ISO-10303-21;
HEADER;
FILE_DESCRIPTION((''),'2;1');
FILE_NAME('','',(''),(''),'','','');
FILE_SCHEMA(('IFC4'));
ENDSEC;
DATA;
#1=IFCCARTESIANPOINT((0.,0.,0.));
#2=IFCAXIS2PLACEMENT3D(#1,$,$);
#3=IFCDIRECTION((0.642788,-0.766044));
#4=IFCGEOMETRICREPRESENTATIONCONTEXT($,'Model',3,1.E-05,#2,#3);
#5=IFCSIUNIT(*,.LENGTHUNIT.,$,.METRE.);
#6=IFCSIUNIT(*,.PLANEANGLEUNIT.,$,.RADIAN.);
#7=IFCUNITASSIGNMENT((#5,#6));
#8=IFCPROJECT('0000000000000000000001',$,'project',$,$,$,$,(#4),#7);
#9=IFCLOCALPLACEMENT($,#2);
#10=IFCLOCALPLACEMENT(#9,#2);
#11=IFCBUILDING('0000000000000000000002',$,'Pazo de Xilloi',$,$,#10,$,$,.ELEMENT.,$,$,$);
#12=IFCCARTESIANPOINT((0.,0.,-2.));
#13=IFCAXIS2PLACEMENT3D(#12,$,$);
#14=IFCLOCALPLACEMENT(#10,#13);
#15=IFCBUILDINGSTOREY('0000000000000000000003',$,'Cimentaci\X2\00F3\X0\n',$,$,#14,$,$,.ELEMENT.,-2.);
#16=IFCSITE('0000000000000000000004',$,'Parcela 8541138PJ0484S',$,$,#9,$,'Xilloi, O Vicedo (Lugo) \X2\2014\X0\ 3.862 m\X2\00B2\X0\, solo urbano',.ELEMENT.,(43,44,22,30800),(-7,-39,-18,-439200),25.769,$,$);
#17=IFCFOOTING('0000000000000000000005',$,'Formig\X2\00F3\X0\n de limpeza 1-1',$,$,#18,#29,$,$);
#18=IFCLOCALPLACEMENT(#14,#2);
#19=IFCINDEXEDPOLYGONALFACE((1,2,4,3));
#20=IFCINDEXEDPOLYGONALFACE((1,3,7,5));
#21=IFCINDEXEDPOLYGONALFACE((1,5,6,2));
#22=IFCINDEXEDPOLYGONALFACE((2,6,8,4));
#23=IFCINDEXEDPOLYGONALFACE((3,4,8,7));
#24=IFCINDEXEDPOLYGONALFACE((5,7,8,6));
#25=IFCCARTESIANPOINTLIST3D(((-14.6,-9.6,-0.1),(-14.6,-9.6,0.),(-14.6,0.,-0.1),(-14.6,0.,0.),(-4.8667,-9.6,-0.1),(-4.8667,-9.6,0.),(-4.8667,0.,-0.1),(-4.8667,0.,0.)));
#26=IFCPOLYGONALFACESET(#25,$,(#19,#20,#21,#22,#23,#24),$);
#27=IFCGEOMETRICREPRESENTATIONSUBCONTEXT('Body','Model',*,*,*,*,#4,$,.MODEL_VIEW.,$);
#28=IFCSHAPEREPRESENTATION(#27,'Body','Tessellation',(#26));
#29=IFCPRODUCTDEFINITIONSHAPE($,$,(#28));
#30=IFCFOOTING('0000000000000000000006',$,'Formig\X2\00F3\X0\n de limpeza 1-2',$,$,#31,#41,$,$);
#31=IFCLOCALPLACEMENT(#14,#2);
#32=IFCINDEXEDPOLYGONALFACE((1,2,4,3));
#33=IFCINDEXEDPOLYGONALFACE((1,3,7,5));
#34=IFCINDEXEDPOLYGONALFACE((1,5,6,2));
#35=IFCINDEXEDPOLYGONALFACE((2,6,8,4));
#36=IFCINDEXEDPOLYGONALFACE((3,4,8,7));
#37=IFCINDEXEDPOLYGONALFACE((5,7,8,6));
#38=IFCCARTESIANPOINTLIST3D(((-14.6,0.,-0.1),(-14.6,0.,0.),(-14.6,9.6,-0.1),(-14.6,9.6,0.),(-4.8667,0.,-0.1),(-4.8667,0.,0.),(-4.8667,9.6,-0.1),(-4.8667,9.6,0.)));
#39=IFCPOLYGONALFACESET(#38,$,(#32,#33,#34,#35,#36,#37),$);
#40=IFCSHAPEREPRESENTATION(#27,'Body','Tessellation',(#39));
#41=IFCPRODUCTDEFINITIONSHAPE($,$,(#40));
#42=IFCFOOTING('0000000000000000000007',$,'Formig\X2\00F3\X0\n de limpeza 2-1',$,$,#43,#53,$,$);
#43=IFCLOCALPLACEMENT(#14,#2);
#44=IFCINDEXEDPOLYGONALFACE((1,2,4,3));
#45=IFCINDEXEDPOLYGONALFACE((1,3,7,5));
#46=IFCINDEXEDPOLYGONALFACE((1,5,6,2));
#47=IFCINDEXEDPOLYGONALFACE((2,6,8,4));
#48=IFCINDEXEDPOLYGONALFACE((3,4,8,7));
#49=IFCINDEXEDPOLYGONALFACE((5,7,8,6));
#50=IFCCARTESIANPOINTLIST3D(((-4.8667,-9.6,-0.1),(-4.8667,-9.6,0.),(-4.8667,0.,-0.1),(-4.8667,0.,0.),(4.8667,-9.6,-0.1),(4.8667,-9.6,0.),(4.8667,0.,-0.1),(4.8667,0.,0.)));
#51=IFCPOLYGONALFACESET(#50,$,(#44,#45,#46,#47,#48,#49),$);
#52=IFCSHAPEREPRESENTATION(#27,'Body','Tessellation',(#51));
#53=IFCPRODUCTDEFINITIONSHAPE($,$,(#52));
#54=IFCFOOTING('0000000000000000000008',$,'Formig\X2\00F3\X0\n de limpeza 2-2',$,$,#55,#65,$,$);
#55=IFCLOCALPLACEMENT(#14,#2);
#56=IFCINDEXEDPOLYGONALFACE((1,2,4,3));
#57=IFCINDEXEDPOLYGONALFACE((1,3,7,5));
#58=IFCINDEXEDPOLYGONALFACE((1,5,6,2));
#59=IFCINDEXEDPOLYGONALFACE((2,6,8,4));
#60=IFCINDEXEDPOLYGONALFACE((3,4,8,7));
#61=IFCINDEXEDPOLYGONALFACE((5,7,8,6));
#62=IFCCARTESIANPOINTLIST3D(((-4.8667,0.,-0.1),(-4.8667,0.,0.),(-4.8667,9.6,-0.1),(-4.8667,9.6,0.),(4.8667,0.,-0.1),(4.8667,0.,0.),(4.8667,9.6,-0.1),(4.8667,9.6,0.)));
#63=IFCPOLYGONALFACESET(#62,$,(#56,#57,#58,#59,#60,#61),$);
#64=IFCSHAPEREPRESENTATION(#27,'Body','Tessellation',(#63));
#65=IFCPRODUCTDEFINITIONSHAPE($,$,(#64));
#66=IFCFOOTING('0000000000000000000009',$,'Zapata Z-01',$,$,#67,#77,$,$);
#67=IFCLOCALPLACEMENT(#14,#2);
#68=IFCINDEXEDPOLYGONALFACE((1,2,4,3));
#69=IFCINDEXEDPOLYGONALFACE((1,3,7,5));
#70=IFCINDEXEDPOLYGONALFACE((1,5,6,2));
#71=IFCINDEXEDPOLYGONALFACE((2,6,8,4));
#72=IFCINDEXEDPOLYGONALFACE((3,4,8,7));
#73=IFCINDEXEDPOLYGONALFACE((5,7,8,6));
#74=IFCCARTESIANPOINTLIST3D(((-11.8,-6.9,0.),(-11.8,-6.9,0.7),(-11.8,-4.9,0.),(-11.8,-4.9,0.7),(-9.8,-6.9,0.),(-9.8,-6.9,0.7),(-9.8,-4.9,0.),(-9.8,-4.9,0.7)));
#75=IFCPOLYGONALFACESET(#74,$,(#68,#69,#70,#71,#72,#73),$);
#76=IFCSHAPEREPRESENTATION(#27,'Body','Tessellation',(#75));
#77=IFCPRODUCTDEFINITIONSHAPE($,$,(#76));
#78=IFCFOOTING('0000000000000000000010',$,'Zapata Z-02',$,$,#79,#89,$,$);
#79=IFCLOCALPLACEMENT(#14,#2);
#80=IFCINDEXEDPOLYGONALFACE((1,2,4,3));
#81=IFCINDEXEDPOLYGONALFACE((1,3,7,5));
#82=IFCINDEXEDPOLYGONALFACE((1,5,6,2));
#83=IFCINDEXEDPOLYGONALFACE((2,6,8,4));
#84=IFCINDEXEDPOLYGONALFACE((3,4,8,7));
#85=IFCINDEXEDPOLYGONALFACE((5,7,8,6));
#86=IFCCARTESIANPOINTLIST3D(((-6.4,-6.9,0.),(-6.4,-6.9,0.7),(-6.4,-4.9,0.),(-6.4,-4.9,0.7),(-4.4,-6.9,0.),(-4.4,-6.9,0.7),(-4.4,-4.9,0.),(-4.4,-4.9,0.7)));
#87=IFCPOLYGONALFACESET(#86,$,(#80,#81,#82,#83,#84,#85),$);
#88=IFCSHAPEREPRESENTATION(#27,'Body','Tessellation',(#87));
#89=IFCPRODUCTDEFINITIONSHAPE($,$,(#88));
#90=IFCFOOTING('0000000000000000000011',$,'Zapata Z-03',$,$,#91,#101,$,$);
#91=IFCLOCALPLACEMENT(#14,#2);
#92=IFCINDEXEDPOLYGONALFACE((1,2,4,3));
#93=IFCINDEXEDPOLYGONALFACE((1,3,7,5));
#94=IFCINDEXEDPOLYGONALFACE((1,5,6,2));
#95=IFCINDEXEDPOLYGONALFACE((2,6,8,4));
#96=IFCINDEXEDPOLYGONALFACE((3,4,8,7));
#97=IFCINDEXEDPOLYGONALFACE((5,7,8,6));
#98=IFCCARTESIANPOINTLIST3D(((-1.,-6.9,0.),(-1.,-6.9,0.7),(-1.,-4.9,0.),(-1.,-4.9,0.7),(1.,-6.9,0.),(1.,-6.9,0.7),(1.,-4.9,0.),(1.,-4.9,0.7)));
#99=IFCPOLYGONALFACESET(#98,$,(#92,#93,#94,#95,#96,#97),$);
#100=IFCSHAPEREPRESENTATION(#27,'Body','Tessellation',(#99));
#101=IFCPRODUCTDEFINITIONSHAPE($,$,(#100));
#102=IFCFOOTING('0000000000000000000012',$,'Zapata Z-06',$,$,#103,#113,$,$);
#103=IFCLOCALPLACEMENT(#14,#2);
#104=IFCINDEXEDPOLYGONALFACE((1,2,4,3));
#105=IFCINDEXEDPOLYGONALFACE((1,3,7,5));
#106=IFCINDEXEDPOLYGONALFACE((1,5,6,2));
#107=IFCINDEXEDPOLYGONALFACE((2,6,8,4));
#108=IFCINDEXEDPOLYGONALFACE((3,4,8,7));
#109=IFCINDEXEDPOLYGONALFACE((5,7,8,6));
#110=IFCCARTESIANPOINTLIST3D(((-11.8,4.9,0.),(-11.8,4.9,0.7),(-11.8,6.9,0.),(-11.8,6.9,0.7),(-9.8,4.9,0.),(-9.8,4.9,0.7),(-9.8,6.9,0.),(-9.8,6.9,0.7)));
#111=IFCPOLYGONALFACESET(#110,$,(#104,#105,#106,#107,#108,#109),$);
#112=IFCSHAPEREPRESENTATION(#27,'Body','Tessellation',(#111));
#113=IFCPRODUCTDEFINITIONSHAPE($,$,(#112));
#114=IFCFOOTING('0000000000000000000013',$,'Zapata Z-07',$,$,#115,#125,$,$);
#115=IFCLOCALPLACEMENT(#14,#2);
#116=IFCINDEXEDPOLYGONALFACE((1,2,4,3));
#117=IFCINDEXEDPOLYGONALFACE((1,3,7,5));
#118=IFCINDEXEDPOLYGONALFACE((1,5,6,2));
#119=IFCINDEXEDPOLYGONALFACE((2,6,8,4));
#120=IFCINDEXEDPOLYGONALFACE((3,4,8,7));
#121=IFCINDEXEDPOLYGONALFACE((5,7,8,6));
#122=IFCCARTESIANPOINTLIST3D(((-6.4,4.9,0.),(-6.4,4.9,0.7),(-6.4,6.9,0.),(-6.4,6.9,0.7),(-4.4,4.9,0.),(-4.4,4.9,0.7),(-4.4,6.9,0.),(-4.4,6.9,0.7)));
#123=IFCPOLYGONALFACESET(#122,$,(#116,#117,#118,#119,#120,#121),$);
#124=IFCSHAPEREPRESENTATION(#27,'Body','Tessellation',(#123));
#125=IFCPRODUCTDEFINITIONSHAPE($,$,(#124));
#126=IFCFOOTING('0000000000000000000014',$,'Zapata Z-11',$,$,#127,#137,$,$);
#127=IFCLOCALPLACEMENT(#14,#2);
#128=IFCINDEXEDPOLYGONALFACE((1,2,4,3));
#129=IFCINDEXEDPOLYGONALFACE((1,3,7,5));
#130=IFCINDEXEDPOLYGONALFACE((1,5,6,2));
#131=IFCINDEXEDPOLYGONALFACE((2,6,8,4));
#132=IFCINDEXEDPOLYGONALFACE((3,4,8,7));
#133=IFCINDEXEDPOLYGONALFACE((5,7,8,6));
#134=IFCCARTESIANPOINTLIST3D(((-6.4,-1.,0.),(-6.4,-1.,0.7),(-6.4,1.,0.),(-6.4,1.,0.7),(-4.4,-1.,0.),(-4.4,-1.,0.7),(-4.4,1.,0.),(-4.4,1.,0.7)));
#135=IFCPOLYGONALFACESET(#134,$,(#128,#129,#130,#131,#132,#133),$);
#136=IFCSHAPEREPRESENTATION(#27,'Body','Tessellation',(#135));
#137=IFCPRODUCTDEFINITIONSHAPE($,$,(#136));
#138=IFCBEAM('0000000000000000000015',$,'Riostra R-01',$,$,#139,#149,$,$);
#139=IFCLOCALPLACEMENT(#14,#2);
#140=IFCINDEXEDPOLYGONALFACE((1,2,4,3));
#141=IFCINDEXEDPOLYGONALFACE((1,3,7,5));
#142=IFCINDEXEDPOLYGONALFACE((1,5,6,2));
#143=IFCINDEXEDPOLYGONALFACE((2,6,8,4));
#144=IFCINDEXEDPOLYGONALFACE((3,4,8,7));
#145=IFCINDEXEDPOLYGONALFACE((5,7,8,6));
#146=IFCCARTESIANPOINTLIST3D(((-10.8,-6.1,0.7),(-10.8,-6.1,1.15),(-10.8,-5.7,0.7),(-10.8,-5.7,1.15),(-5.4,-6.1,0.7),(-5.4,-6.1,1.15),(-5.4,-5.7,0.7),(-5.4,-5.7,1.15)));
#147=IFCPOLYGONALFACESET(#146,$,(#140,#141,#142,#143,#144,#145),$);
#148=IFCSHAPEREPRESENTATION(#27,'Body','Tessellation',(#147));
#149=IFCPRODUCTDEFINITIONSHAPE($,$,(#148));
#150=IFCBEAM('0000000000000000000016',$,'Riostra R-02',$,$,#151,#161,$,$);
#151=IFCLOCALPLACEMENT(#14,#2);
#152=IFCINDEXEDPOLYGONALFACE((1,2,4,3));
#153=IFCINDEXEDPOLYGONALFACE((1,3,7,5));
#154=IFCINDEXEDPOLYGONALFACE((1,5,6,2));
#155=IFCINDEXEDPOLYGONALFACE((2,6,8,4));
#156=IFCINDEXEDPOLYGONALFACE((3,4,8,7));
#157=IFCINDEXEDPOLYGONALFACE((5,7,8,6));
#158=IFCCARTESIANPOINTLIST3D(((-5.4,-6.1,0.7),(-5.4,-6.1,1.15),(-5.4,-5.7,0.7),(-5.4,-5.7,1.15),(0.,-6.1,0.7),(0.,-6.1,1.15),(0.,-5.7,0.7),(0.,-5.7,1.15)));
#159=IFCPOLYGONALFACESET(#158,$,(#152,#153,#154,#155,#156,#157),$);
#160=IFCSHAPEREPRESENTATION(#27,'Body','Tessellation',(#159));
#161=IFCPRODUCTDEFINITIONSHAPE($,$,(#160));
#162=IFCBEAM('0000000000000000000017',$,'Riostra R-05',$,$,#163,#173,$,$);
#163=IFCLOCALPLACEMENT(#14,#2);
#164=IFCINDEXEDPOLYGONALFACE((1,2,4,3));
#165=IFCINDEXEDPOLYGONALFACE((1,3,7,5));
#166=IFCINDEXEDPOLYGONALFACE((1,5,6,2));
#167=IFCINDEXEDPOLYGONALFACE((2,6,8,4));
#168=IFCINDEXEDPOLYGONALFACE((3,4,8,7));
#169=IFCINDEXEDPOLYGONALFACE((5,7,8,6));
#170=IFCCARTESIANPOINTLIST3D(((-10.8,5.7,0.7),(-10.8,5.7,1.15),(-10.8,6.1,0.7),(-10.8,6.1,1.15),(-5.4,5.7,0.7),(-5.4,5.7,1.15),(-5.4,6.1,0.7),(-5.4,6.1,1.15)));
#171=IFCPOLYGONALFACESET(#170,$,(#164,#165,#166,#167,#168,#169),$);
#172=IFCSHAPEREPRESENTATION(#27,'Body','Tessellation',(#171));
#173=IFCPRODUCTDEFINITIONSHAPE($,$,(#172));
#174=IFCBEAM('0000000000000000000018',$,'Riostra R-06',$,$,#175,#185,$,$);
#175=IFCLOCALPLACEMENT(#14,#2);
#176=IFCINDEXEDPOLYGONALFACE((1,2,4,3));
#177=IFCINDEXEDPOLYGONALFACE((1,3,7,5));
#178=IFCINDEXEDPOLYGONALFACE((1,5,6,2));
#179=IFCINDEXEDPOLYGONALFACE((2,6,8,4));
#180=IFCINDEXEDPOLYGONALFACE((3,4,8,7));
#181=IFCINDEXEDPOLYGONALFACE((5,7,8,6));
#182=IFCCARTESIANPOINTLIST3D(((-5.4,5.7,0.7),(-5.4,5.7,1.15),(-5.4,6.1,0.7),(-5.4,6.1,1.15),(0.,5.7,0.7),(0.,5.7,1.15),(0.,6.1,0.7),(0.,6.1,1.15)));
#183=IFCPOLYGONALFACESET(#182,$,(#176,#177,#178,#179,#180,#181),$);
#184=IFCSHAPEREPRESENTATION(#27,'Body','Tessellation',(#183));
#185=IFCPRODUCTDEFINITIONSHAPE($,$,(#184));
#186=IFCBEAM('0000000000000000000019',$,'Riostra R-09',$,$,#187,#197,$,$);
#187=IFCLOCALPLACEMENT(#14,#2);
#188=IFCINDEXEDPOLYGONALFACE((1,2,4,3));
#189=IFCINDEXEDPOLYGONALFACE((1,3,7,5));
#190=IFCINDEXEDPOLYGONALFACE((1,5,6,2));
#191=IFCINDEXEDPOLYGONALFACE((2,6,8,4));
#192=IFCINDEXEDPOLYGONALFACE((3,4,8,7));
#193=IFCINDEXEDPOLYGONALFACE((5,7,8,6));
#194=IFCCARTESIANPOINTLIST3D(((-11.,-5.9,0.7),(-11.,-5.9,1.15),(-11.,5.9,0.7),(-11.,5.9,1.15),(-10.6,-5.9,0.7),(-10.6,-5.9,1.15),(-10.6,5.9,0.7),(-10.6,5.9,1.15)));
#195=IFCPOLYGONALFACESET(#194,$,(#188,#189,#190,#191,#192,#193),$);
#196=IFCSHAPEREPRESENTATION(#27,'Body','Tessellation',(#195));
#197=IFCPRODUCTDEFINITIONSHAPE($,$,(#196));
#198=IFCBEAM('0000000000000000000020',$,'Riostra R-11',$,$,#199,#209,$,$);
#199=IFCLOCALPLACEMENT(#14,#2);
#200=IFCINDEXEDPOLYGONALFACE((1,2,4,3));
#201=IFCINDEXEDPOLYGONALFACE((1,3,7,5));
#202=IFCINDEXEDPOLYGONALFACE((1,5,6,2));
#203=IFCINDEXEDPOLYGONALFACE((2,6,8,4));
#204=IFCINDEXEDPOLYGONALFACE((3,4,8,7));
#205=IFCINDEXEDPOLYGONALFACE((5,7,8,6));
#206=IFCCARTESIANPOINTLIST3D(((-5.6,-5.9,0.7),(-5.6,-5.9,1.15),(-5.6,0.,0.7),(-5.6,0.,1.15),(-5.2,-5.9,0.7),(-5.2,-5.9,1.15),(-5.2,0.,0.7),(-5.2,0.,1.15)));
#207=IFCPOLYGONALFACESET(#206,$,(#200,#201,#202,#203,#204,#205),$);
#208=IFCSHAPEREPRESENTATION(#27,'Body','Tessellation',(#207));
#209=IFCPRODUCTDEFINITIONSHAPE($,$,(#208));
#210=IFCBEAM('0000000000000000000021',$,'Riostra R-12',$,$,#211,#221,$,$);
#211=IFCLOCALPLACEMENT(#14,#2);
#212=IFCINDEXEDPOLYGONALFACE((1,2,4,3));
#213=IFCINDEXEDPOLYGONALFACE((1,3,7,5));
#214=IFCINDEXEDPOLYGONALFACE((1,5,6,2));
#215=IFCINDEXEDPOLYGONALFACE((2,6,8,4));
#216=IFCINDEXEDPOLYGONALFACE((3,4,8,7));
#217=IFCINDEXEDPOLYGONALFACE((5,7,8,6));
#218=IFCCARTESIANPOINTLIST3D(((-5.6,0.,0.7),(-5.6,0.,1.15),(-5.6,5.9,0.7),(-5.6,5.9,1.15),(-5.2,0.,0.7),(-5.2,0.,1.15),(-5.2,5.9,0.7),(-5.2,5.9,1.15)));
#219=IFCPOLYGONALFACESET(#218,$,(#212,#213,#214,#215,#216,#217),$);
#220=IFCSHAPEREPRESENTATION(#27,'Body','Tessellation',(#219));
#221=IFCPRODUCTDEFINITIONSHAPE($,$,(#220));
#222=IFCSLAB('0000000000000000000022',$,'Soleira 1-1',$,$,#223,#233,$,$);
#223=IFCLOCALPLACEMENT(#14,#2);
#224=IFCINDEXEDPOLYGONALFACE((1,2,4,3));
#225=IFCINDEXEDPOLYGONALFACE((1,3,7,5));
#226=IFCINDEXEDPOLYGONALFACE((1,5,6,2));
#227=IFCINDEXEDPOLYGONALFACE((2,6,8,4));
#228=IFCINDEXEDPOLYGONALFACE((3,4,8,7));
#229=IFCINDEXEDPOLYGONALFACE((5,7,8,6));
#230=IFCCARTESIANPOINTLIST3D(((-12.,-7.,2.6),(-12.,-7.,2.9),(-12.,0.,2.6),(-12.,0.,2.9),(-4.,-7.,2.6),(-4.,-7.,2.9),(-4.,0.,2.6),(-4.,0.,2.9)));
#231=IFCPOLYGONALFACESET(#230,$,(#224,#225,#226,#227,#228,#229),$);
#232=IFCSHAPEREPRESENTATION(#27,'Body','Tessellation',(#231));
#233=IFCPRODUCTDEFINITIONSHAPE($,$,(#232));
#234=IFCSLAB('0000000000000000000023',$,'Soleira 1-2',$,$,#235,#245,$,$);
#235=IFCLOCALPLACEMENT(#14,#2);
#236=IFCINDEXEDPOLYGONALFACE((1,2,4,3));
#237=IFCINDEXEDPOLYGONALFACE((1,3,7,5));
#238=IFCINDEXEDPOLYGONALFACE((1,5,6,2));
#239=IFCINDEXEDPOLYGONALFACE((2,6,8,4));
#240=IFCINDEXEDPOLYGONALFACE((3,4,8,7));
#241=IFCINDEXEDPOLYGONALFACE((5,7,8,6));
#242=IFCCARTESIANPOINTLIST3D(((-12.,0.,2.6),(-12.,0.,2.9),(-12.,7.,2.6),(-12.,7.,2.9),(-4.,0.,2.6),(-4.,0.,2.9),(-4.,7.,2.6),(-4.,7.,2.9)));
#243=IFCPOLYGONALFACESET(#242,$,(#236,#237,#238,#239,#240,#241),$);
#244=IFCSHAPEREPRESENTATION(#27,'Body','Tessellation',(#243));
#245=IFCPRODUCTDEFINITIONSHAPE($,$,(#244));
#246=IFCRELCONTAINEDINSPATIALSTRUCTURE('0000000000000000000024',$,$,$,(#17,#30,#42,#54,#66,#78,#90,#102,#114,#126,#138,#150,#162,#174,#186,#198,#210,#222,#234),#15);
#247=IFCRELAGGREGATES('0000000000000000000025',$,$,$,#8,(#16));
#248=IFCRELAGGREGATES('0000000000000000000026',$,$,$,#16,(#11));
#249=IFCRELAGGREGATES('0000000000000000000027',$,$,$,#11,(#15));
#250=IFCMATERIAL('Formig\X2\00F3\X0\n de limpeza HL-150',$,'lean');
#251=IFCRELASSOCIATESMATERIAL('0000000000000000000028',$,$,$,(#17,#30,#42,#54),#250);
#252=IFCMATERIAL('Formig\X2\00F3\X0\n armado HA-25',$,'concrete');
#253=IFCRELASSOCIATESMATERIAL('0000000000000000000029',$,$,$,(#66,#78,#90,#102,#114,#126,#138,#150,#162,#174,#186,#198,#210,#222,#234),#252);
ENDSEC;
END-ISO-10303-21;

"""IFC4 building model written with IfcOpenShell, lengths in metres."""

from ifc_helpers import new_model, si_unit, direction, frame, origin, origin_2d, place, context, subcontext, project, spatial, rectangle, extrude, material, element, save


model = new_model("IFC4")

# Units and contexts
model_context = context("Model", 3, precision=1e-05, world=origin(), true_north=direction((0.642788, -0.766044)))
body_context = subcontext(model_context, "Body", "Model", "MODEL_VIEW")
ifc_project = project(units=[si_unit("LENGTHUNIT", "METRE"), si_unit("PLANEANGLEUNIT", "RADIAN")], contexts=[model_context])

# Site, building, storey
site_placement = place(None, origin())
site = spatial("IfcSite", under=ifc_project, at=site_placement, Name="Parcela 8541138PJ0484S", LongName="Xilloi, O Vicedo (Lugo) — 3.862 m², solo urbano", CompositionType="ELEMENT", RefLatitude=(43, 44, 22, 30800), RefLongitude=(-7, -39, -18, -439200), RefElevation=25.769)
building_placement = place(site_placement, origin())
building = spatial("IfcBuilding", under=site, at=building_placement, Name="Pazo de Xilloi", CompositionType="ELEMENT")
storey_placement = place(building_placement, frame((0.0, 0.0, -2.0)))
storey = spatial("IfcBuildingStorey", under=building, at=storey_placement, Name="Cimentación", CompositionType="ELEMENT", Elevation=-2.0)

# Footings
ifc_material_1 = material(Name="Formigón de limpeza HL-150", Category="lean")
for number, where, name in (
    (1, (-9.7333, -4.8, -0.05), "Formigón de limpeza 1-1"),
    (2, (-9.7333, 4.8, -0.05), "Formigón de limpeza 1-2"),
    (3, (0.0, -4.8, -0.05), "Formigón de limpeza 2-1"),
    (4, (0.0, 4.8, -0.05), "Formigón de limpeza 2-2"),
):
    element("IfcFooting", number, at=place(storey_placement, frame(where)), inside=storey, material=ifc_material_1, Name=name, context=body_context, shape_type="SweptSolid", body=[
        extrude(rectangle(XDim=9.7333, YDim=9.6, at=origin_2d()), frame((0.0, 0.0, -0.05)), (0.0, 0.0, 1.0), 0.1),
    ])
ifc_material_2 = material(Name="Formigón armado HA-25", Category="concrete")
for number, where, name in (
    (5, (-10.8, -5.9, 0.35), "Zapata Z-01"),
    (6, (-5.4, -5.9, 0.35), "Zapata Z-02"),
    (7, (0.0, -5.9, 0.35), "Zapata Z-03"),
    (8, (-10.8, 5.9, 0.35), "Zapata Z-06"),
    (9, (-5.4, 5.9, 0.35), "Zapata Z-07"),
    (10, (-5.4, 0.0, 0.35), "Zapata Z-11"),
):
    element("IfcFooting", number, at=place(storey_placement, frame(where)), inside=storey, material=ifc_material_2, Name=name, context=body_context, shape_type="SweptSolid", body=[
        extrude(rectangle(XDim=2.0, YDim=2.0, at=origin_2d()), frame((0.0, 0.0, -0.35)), (0.0, 0.0, 1.0), 0.7),
    ])

# Beams
for number, where, name in (
    (11, (-8.1, -5.9, 0.925), "Riostra R-01"),
    (12, (-2.7, -5.9, 0.925), "Riostra R-02"),
    (13, (-8.1, 5.9, 0.925), "Riostra R-05"),
    (14, (-2.7, 5.9, 0.925), "Riostra R-06"),
):
    element("IfcBeam", number, at=place(storey_placement, frame(where)), inside=storey, material=ifc_material_2, Name=name, context=body_context, shape_type="SweptSolid", body=[
        extrude(rectangle(XDim=5.4, YDim=0.4, at=origin_2d()), frame((0.0, 0.0, -0.225)), (0.0, 0.0, 1.0), 0.45),
    ])
beam_placement = place(storey_placement, frame((-10.8, 0.0, 0.925)))
element("IfcBeam", 15, at=beam_placement, inside=storey, material=ifc_material_2, Name="Riostra R-09", context=body_context, shape_type="SweptSolid", body=[
    extrude(rectangle(XDim=0.4, YDim=11.8, at=origin_2d()), frame((0.0, 0.0, -0.225)), (0.0, 0.0, 1.0), 0.45),
])
for number, where, name in (
    (16, (-5.4, -2.95, 0.925), "Riostra R-11"),
    (17, (-5.4, 2.95, 0.925), "Riostra R-12"),
):
    element("IfcBeam", number, at=place(storey_placement, frame(where)), inside=storey, material=ifc_material_2, Name=name, context=body_context, shape_type="SweptSolid", body=[
        extrude(rectangle(XDim=0.4, YDim=5.9, at=origin_2d()), frame((0.0, 0.0, -0.225)), (0.0, 0.0, 1.0), 0.45),
    ])

# Slabs
for number, where, name in (
    (18, (-8.0, -3.5, 2.75), "Soleira 1-1"),
    (19, (-8.0, 3.5, 2.75), "Soleira 1-2"),
):
    element("IfcSlab", number, at=place(storey_placement, frame(where)), inside=storey, material=ifc_material_2, Name=name, context=body_context, shape_type="SweptSolid", body=[
        extrude(rectangle(XDim=8.0, YDim=7.0, at=origin_2d()), frame((0.0, 0.0, -0.15)), (0.0, 0.0, 1.0), 0.3),
    ])

save(model, "model.ifc")
